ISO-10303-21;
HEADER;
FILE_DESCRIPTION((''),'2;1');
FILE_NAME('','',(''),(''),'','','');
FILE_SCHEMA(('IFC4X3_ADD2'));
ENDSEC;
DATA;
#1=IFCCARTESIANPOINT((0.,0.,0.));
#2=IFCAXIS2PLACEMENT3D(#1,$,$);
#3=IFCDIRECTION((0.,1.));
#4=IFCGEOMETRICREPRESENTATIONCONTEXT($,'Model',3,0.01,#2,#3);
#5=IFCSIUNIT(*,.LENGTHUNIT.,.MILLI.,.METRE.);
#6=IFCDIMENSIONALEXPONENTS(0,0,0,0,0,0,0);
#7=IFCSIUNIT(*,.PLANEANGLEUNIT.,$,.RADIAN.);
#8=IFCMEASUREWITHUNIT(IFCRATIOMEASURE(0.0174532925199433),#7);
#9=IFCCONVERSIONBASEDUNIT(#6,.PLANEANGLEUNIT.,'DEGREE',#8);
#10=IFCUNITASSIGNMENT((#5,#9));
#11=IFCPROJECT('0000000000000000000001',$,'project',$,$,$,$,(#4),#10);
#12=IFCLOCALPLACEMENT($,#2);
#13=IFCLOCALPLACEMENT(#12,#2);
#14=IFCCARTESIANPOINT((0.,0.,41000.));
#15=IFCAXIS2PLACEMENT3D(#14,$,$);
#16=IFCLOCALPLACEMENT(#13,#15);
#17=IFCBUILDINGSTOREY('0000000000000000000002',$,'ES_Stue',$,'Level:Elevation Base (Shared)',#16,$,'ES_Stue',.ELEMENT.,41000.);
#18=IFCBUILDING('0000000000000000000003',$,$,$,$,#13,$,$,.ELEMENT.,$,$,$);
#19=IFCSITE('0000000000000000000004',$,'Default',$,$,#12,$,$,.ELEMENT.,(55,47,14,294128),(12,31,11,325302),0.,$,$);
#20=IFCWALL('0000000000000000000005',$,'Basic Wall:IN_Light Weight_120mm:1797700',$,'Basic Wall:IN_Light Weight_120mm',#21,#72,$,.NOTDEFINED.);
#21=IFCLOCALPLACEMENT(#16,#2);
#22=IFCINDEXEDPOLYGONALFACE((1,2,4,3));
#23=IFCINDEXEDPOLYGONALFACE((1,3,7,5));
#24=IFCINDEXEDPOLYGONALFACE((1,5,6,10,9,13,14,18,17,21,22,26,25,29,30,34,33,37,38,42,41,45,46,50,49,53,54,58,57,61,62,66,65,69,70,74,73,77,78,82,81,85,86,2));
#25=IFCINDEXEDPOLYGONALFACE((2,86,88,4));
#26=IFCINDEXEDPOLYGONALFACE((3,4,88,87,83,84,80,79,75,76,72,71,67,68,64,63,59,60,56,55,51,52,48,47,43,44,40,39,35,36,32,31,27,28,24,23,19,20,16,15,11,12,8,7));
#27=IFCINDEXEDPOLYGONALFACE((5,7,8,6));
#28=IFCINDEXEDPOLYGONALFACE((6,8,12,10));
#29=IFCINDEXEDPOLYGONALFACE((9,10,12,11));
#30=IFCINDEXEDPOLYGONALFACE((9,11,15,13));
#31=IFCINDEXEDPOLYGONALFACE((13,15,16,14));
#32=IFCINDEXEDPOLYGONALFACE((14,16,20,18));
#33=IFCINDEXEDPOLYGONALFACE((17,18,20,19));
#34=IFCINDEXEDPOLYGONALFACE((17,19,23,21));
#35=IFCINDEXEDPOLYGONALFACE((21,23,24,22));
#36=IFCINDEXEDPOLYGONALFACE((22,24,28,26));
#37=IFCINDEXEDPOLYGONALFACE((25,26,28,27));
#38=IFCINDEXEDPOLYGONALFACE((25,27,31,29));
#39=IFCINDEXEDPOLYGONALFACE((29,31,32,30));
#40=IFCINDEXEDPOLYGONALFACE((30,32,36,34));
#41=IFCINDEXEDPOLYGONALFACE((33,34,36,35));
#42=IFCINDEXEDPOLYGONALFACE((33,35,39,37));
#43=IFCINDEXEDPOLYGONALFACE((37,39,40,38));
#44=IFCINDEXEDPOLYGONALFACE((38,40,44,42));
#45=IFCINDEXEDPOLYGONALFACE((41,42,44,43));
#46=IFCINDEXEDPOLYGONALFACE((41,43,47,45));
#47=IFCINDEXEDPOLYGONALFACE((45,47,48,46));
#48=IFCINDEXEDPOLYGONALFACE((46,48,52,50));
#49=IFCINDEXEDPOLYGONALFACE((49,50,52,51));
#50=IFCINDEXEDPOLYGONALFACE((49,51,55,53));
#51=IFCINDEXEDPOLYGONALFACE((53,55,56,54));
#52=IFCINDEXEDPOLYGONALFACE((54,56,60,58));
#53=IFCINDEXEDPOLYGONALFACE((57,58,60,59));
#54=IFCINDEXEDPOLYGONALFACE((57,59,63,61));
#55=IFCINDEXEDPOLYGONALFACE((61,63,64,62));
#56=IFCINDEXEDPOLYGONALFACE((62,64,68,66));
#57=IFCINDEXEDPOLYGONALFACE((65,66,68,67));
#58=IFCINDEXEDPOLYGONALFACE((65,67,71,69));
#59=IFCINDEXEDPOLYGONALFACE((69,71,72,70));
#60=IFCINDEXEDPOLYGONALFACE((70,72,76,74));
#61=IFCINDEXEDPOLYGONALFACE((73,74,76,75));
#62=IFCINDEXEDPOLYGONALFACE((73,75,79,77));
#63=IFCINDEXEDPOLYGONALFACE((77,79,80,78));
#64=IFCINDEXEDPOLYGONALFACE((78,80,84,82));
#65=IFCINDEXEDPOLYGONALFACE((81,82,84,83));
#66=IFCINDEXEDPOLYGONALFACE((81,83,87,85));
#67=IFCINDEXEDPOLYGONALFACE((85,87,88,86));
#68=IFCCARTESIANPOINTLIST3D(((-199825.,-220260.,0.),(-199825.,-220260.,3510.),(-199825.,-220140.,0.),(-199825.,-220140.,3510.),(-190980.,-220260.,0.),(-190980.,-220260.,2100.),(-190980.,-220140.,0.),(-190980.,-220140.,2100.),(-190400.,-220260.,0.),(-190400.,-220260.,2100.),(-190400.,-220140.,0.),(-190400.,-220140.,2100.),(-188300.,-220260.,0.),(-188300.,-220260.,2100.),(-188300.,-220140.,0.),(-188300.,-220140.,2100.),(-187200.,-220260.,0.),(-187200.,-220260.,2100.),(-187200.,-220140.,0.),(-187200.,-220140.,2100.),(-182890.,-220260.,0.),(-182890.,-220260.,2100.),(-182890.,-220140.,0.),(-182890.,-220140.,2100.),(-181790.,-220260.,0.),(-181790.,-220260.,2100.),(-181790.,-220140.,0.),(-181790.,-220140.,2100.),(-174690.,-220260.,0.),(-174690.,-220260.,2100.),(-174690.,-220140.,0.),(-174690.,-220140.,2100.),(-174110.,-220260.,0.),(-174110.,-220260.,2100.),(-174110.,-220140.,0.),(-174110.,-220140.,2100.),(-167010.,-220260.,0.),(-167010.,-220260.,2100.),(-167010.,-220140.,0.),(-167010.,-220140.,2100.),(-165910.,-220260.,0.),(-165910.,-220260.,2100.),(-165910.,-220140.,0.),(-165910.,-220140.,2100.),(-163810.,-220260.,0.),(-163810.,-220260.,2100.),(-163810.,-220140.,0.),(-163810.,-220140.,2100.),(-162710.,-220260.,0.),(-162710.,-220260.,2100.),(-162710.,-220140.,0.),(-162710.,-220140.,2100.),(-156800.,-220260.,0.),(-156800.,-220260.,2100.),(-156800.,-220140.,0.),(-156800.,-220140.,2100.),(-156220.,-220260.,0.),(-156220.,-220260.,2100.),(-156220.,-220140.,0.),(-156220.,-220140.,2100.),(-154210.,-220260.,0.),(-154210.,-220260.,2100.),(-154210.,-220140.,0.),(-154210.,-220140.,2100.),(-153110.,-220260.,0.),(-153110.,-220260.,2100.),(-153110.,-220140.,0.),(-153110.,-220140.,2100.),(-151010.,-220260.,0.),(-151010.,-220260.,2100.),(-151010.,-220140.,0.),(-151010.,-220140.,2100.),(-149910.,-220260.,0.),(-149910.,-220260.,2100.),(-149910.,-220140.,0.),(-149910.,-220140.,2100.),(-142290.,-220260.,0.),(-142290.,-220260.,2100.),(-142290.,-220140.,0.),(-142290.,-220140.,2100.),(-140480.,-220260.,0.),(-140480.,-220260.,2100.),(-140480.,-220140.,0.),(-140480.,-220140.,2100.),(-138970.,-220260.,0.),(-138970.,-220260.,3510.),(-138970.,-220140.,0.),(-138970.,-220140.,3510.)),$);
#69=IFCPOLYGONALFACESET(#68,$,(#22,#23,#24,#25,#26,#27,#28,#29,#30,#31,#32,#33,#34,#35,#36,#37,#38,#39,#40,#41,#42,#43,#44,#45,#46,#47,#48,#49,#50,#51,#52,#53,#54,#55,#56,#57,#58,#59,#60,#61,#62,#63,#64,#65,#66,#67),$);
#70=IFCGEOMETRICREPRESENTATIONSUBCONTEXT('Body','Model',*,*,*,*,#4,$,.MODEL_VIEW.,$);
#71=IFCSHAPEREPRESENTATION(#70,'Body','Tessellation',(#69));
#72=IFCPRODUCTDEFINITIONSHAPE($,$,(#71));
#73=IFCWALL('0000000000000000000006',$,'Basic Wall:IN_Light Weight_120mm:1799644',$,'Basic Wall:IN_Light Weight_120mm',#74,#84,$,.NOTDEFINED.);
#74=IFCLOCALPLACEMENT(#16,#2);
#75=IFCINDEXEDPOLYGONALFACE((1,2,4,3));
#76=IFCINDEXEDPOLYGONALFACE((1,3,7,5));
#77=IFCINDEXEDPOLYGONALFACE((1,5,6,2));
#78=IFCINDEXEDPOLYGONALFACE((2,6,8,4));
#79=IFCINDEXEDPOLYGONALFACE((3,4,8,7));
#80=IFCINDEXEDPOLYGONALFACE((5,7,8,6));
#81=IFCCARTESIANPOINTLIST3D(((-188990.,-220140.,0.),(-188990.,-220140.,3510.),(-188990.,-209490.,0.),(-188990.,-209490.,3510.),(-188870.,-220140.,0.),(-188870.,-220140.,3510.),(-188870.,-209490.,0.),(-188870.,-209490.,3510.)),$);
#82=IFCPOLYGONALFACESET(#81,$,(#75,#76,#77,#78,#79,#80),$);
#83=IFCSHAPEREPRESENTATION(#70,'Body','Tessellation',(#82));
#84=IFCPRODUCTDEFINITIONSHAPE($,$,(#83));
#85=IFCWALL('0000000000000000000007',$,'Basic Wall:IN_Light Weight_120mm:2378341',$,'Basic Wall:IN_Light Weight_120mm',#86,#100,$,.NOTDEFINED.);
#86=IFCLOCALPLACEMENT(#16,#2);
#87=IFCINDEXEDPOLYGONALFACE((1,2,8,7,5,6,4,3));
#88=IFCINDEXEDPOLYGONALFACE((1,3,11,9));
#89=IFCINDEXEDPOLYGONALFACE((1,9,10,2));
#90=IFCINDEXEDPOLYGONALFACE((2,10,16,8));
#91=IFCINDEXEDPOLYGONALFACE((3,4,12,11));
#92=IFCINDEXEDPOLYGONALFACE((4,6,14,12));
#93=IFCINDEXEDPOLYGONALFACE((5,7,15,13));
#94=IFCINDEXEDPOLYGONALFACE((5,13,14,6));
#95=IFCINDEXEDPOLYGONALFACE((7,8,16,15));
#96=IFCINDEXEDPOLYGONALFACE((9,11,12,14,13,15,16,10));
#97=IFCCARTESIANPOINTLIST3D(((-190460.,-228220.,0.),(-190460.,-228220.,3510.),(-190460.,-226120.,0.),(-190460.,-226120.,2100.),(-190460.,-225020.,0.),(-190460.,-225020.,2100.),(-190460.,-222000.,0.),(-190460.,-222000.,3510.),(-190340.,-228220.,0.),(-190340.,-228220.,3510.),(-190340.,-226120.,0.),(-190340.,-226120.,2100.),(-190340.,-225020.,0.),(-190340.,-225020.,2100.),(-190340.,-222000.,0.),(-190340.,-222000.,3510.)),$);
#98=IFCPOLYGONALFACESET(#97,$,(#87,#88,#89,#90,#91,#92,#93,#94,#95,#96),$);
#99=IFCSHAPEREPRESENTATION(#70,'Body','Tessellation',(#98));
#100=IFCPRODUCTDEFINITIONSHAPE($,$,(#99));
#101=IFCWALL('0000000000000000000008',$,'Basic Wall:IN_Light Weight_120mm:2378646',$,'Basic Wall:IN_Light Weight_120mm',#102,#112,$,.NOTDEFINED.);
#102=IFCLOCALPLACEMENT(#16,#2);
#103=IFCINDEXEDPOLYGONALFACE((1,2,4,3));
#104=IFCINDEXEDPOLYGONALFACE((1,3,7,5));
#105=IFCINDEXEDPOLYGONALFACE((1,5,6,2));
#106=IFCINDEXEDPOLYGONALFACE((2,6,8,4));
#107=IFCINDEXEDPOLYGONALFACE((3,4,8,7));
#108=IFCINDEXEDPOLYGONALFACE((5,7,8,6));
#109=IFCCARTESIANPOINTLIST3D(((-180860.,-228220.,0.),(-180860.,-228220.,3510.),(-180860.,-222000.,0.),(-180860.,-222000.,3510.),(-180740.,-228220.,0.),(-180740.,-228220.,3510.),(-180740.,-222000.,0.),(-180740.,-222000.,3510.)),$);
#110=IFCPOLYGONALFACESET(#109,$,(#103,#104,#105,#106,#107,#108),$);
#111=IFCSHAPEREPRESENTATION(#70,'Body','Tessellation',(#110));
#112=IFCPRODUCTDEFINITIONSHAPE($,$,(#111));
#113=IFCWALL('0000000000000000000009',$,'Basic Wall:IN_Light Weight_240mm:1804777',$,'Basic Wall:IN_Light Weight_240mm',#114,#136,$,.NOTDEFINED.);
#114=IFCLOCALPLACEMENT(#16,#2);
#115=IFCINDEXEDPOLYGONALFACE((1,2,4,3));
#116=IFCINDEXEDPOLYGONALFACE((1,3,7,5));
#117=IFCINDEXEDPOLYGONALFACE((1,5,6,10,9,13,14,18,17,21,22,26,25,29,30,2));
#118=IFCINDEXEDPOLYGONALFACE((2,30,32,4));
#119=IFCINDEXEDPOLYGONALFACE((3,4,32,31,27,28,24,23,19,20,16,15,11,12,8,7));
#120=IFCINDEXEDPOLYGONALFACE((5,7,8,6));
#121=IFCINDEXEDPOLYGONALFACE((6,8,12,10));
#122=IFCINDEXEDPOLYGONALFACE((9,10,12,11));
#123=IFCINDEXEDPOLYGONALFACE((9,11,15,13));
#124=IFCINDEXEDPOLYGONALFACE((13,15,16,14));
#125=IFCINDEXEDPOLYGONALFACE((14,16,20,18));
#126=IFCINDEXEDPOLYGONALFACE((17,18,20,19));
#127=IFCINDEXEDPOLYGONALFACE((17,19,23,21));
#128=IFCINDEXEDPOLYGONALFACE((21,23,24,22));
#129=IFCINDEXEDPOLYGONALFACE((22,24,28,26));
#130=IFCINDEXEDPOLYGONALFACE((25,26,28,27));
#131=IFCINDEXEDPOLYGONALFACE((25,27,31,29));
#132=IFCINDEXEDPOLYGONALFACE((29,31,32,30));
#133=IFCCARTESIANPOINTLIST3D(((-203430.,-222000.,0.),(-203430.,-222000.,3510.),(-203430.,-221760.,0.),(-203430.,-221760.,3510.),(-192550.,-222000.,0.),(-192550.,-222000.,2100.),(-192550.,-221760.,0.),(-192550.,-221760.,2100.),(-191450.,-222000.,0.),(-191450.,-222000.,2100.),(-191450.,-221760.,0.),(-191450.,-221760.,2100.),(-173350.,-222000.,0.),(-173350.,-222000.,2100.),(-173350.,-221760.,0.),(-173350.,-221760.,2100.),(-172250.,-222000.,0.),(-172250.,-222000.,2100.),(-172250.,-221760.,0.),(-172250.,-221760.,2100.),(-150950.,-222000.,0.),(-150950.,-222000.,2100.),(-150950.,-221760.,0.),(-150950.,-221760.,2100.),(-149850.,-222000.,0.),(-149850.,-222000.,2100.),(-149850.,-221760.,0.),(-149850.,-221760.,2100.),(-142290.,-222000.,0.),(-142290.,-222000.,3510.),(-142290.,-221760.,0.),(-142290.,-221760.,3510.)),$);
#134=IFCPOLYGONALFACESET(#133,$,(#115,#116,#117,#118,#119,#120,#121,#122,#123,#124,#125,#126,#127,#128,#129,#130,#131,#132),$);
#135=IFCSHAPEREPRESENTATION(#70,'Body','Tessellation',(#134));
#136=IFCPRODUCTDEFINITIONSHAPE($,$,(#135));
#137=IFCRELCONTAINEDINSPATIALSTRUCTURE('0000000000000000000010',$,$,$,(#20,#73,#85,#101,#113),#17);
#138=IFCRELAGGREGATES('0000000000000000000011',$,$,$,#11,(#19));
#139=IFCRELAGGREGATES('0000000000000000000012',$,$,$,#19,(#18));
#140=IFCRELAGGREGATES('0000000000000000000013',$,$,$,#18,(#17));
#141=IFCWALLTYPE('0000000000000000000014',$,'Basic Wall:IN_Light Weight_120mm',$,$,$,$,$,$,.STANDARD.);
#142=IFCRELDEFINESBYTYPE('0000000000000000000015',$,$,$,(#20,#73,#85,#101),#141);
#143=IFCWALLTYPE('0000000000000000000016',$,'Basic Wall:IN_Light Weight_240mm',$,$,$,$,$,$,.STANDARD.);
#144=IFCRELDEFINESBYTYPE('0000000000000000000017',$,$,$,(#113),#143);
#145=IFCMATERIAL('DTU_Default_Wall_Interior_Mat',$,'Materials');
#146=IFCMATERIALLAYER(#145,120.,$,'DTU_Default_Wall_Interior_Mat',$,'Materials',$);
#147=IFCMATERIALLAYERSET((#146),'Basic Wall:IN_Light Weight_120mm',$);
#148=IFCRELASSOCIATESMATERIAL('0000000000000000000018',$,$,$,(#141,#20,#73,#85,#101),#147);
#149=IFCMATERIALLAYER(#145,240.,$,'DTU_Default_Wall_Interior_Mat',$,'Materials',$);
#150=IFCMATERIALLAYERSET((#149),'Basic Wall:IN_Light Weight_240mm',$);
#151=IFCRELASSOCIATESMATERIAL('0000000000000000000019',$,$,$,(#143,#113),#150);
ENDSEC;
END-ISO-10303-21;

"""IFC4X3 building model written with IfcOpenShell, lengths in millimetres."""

from ifc_helpers import new_model, entity, si_unit, converted_unit, direction, frame, frame_2d, origin, place, context, subcontext, project, spatial, rectangle, extrude, material, layer, layer_set, type_object, element, save


model = new_model("IFC4X3")

# Units and contexts
model_context = context("Model", 3, precision=0.01, world=origin(), true_north=direction((0.0, 1.0)))
body_context = subcontext(model_context, "Body", "Model", "MODEL_VIEW")
ifc_project = project(units=[si_unit("LENGTHUNIT", "METRE", prefix="MILLI"), converted_unit("PLANEANGLEUNIT", "DEGREE", entity("IfcRatioMeasure", 0.0174532925199433), si_unit("PLANEANGLEUNIT", "RADIAN"), dimensions=[0, 0, 0, 0, 0, 0, 0])], contexts=[model_context])

# Site, building, storey
site_placement = place(None, origin())
site = spatial("IfcSite", under=ifc_project, at=site_placement, Name="Default", CompositionType="ELEMENT", RefLatitude=(55, 47, 14, 294128), RefLongitude=(12, 31, 11, 325302), RefElevation=0.0)
building_placement = place(site_placement, origin())
building = spatial("IfcBuilding", under=site, at=building_placement, CompositionType="ELEMENT")
storey_placement = place(building_placement, frame((0.0, 0.0, 41000.0)))
storey = spatial("IfcBuildingStorey", under=building, at=storey_placement, Name="ES_Stue", ObjectType="Level:Elevation Base (Shared)", LongName="ES_Stue", CompositionType="ELEMENT", Elevation=41000.0)

# Wall, openings
ifc_material_1 = material(Name="DTU_Default_Wall_Interior_Mat", Category="Materials")
ifc_layer_1 = layer(ifc_material_1, 120.0, Name="DTU_Default_Wall_Interior_Mat", Category="Materials")
ifc_layer_set_1 = layer_set([ifc_layer_1], Name="Basic Wall:IN_Light Weight_120mm")
wall_type_1 = type_object("IfcWallType", Name="Basic Wall:IN_Light Weight_120mm", PredefinedType="STANDARD", material=ifc_layer_set_1)
wall_1_placement = place(storey_placement, frame((-199825.0, -220200.0, 0.0)))
wall_1 = element("IfcWall", 1, at=wall_1_placement, inside=storey, type_object=wall_type_1, material=ifc_layer_set_1, Name="Basic Wall:IN_Light Weight_120mm:1797700", ObjectType="Basic Wall:IN_Light Weight_120mm", PredefinedType="NOTDEFINED", context=body_context, shape_type="SweptSolid", body=[
    extrude(rectangle(XDim=60855.0, YDim=120.0, at=frame_2d((30427.5, 0.0), x_axis=(1.0, 0.0))), origin(), (0.0, 0.0, 1.0), 3510.0),
])
opening_1_placement = place(wall_1_placement, frame((9425.0, 60.0, 0.0)))
element("IfcOpeningElement", 2, at=opening_1_placement, cuts=wall_1, PredefinedType="OPENING", context=body_context, shape_type="SweptSolid", body=[
    extrude(rectangle(XDim=2100.0, YDim=580.0, at=frame_2d((1050.0, 290.0), x_axis=(1.0, 0.0))), frame((0.0, 0.0, 0.0), z_axis=(0.0, -1.0, 0.0), x_axis=(0.0, 0.0, 1.0)), (0.0, 0.0, 1.0), 120.0),
])
opening_2_placement = place(wall_1_placement, frame((11525.0, -60.0, 0.0)))
element("IfcOpeningElement", 3, at=opening_2_placement, cuts=wall_1, PredefinedType="OPENING", context=body_context, shape_type="SweptSolid", body=[
    extrude(rectangle(XDim=2100.0, YDim=1100.0, at=frame_2d((1050.0, 550.0), x_axis=(1.0, 0.0))), frame((0.0, 0.0, 0.0), z_axis=(0.0, 1.0, 0.0), x_axis=(0.0, 0.0, 1.0)), (0.0, 0.0, 1.0), 120.0),
])
opening_3_placement = place(wall_1_placement, frame((16935.0, -60.0, 0.0)))
element("IfcOpeningElement", 4, at=opening_3_placement, cuts=wall_1, PredefinedType="OPENING", context=body_context, shape_type="SweptSolid", body=[
    extrude(rectangle(XDim=2100.0, YDim=1100.0, at=frame_2d((1050.0, 550.0), x_axis=(1.0, 0.0))), frame((0.0, 0.0, 0.0), z_axis=(0.0, 1.0, 0.0), x_axis=(0.0, 0.0, 1.0)), (0.0, 0.0, 1.0), 120.0),
])
opening_4_placement = place(wall_1_placement, frame((33915.0, 60.0, 0.0)))
element("IfcOpeningElement", 5, at=opening_4_placement, cuts=wall_1, PredefinedType="OPENING", context=body_context, shape_type="SweptSolid", body=[
    extrude(rectangle(XDim=2100.0, YDim=1100.0, at=frame_2d((1050.0, 550.0), x_axis=(1.0, 0.0))), frame((0.0, 0.0, 0.0), z_axis=(0.0, -1.0, 0.0), x_axis=(0.0, 0.0, 1.0)), (0.0, 0.0, 1.0), 120.0),
])
opening_5_placement = place(wall_1_placement, frame((25715.0, 60.0, 0.0)))
element("IfcOpeningElement", 6, at=opening_5_placement, cuts=wall_1, PredefinedType="OPENING", context=body_context, shape_type="SweptSolid", body=[
    extrude(rectangle(XDim=2100.0, YDim=580.0, at=frame_2d((1050.0, 290.0), x_axis=(1.0, 0.0))), frame((0.0, 0.0, 0.0), z_axis=(0.0, -1.0, 0.0), x_axis=(0.0, 0.0, 1.0)), (0.0, 0.0, 1.0), 120.0),
])
opening_6_placement = place(wall_1_placement, frame((36015.0, -60.0, 0.0)))
element("IfcOpeningElement", 7, at=opening_6_placement, cuts=wall_1, PredefinedType="OPENING", context=body_context, shape_type="SweptSolid", body=[
    extrude(rectangle(XDim=2100.0, YDim=1100.0, at=frame_2d((1050.0, 550.0), x_axis=(1.0, 0.0))), frame((0.0, 0.0, 0.0), z_axis=(0.0, 1.0, 0.0), x_axis=(0.0, 0.0, 1.0)), (0.0, 0.0, 1.0), 120.0),
])
opening_7_placement = place(wall_1_placement, frame((45615.0, -60.0, 0.0)))
element("IfcOpeningElement", 8, at=opening_7_placement, cuts=wall_1, PredefinedType="OPENING", context=body_context, shape_type="SweptSolid", body=[
    extrude(rectangle(XDim=2100.0, YDim=1100.0, at=frame_2d((1050.0, 550.0), x_axis=(1.0, 0.0))), frame((0.0, 0.0, 0.0), z_axis=(0.0, 1.0, 0.0), x_axis=(0.0, 0.0, 1.0)), (0.0, 0.0, 1.0), 120.0),
])
opening_8_placement = place(wall_1_placement, frame((48815.0, -60.0, 0.0)))
element("IfcOpeningElement", 9, at=opening_8_placement, cuts=wall_1, PredefinedType="OPENING", context=body_context, shape_type="SweptSolid", body=[
    extrude(rectangle(XDim=2100.0, YDim=1100.0, at=frame_2d((1050.0, 550.0), x_axis=(1.0, 0.0))), frame((0.0, 0.0, 0.0), z_axis=(0.0, 1.0, 0.0), x_axis=(0.0, 0.0, 1.0)), (0.0, 0.0, 1.0), 120.0),
])
opening_9_placement = place(wall_1_placement, frame((59345.0, 60.0, 0.0)))
element("IfcOpeningElement", 10, at=opening_9_placement, cuts=wall_1, PredefinedType="OPENING", context=body_context, shape_type="SweptSolid", body=[
    extrude(rectangle(XDim=2100.0, YDim=1810.0, at=frame_2d((1050.0, 905.0), x_axis=(1.0, 0.0))), frame((0.0, 0.0, 0.0), z_axis=(0.0, -1.0, 0.0), x_axis=(0.0, 0.0, 1.0)), (0.0, 0.0, 1.0), 120.0),
])
opening_10_placement = place(wall_1_placement, frame((43025.0, -60.0, 0.0)))
element("IfcOpeningElement", 11, at=opening_10_placement, cuts=wall_1, PredefinedType="OPENING", context=body_context, shape_type="SweptSolid", body=[
    extrude(rectangle(XDim=2100.0, YDim=580.0, at=frame_2d((1050.0, 290.0), x_axis=(1.0, 0.0))), frame((0.0, 0.0, 0.0), z_axis=(0.0, 1.0, 0.0), x_axis=(0.0, 0.0, 1.0)), (0.0, 0.0, 1.0), 120.0),
])

# Wall
wall_2_placement = place(storey_placement, frame((-188930.0, -209490.0, 0.0), z_axis=(0.0, 0.0, 1.0), x_axis=(0.0, -1.0, 0.0)))
element("IfcWall", 12, at=wall_2_placement, inside=storey, type_object=wall_type_1, material=ifc_layer_set_1, Name="Basic Wall:IN_Light Weight_120mm:1799644", ObjectType="Basic Wall:IN_Light Weight_120mm", PredefinedType="NOTDEFINED", context=body_context, shape_type="SweptSolid", body=[
    extrude(rectangle(XDim=10650.0, YDim=120.0, at=frame_2d((5325.0, 0.0), x_axis=(-1.0, 0.0))), origin(), (0.0, 0.0, 1.0), 3510.0),
])

# Wall, opening
wall_3_placement = place(storey_placement, frame((-190400.0, -228220.0, 0.0), z_axis=(0.0, 0.0, 1.0), x_axis=(0.0, 1.0, 0.0)))
wall_3 = element("IfcWall", 13, at=wall_3_placement, inside=storey, type_object=wall_type_1, material=ifc_layer_set_1, Name="Basic Wall:IN_Light Weight_120mm:2378341", ObjectType="Basic Wall:IN_Light Weight_120mm", PredefinedType="NOTDEFINED", context=body_context, shape_type="SweptSolid", body=[
    extrude(rectangle(XDim=6220.0, YDim=120.0, at=frame_2d((3110.0, 0.0), x_axis=(1.0, 0.0))), origin(), (0.0, 0.0, 1.0), 3510.0),
])
opening_11_placement = place(wall_3_placement, frame((2100.0, -60.0, 0.0)))
element("IfcOpeningElement", 14, at=opening_11_placement, cuts=wall_3, PredefinedType="OPENING", context=body_context, shape_type="SweptSolid", body=[
    extrude(rectangle(XDim=2100.0, YDim=1100.0, at=frame_2d((1050.0, 550.0), x_axis=(1.0, 0.0))), frame((0.0, 0.0, 0.0), z_axis=(0.0, 1.0, 0.0), x_axis=(0.0, 0.0, 1.0)), (0.0, 0.0, 1.0), 120.0),
])

# Wall
wall_4_placement = place(storey_placement, frame((-180800.0, -222000.0, 0.0), z_axis=(0.0, 0.0, 1.0), x_axis=(0.0, -1.0, 0.0)))
element("IfcWall", 15, at=wall_4_placement, inside=storey, type_object=wall_type_1, material=ifc_layer_set_1, Name="Basic Wall:IN_Light Weight_120mm:2378646", ObjectType="Basic Wall:IN_Light Weight_120mm", PredefinedType="NOTDEFINED", context=body_context, shape_type="SweptSolid", body=[
    extrude(rectangle(XDim=6220.0, YDim=120.0, at=frame_2d((3110.0, 0.0), x_axis=(-1.0, 0.0))), origin(), (0.0, 0.0, 1.0), 3510.0),
])

# Wall, openings
ifc_layer_2 = layer(ifc_material_1, 240.0, Name="DTU_Default_Wall_Interior_Mat", Category="Materials")
ifc_layer_set_2 = layer_set([ifc_layer_2], Name="Basic Wall:IN_Light Weight_240mm")
wall_type_2 = type_object("IfcWallType", Name="Basic Wall:IN_Light Weight_240mm", PredefinedType="STANDARD", material=ifc_layer_set_2)
wall_5_placement = place(storey_placement, frame((-203430.0, -221880.0, 0.0)))
wall_5 = element("IfcWall", 16, at=wall_5_placement, inside=storey, type_object=wall_type_2, material=ifc_layer_set_2, Name="Basic Wall:IN_Light Weight_240mm:1804777", ObjectType="Basic Wall:IN_Light Weight_240mm", PredefinedType="NOTDEFINED", context=body_context, shape_type="SweptSolid", body=[
    extrude(rectangle(XDim=61140.0, YDim=240.0, at=frame_2d((30570.0, 0.0), x_axis=(-1.0, 0.0))), origin(), (0.0, 0.0, 1.0), 3510.0),
])
opening_12_placement = place(wall_5_placement, frame((53580.0, 120.0, 0.0)))
element("IfcOpeningElement", 17, at=opening_12_placement, cuts=wall_5, PredefinedType="OPENING", context=body_context, shape_type="SweptSolid", body=[
    extrude(rectangle(XDim=2100.0, YDim=1100.0, at=frame_2d((1050.0, 550.0), x_axis=(1.0, 0.0))), frame((0.0, 0.0, 0.0), z_axis=(0.0, -1.0, 0.0), x_axis=(0.0, 0.0, 1.0)), (0.0, 0.0, 1.0), 240.0),
])
opening_13_placement = place(wall_5_placement, frame((11980.0, 120.0, 0.0)))
element("IfcOpeningElement", 18, at=opening_13_placement, cuts=wall_5, PredefinedType="OPENING", context=body_context, shape_type="SweptSolid", body=[
    extrude(rectangle(XDim=2100.0, YDim=1100.0, at=frame_2d((1050.0, 550.0), x_axis=(1.0, 0.0))), frame((0.0, 0.0, 0.0), z_axis=(0.0, -1.0, 0.0), x_axis=(0.0, 0.0, 1.0)), (0.0, 0.0, 1.0), 240.0),
])
opening_14_placement = place(wall_5_placement, frame((31180.0, 120.0, 0.0)))
element("IfcOpeningElement", 19, at=opening_14_placement, cuts=wall_5, PredefinedType="OPENING", context=body_context, shape_type="SweptSolid", body=[
    extrude(rectangle(XDim=2100.0, YDim=1100.0, at=frame_2d((1050.0, 550.0), x_axis=(1.0, 0.0))), frame((0.0, 0.0, 0.0), z_axis=(0.0, -1.0, 0.0), x_axis=(0.0, 0.0, 1.0)), (0.0, 0.0, 1.0), 240.0),
])

save(model, "model.ifc")
